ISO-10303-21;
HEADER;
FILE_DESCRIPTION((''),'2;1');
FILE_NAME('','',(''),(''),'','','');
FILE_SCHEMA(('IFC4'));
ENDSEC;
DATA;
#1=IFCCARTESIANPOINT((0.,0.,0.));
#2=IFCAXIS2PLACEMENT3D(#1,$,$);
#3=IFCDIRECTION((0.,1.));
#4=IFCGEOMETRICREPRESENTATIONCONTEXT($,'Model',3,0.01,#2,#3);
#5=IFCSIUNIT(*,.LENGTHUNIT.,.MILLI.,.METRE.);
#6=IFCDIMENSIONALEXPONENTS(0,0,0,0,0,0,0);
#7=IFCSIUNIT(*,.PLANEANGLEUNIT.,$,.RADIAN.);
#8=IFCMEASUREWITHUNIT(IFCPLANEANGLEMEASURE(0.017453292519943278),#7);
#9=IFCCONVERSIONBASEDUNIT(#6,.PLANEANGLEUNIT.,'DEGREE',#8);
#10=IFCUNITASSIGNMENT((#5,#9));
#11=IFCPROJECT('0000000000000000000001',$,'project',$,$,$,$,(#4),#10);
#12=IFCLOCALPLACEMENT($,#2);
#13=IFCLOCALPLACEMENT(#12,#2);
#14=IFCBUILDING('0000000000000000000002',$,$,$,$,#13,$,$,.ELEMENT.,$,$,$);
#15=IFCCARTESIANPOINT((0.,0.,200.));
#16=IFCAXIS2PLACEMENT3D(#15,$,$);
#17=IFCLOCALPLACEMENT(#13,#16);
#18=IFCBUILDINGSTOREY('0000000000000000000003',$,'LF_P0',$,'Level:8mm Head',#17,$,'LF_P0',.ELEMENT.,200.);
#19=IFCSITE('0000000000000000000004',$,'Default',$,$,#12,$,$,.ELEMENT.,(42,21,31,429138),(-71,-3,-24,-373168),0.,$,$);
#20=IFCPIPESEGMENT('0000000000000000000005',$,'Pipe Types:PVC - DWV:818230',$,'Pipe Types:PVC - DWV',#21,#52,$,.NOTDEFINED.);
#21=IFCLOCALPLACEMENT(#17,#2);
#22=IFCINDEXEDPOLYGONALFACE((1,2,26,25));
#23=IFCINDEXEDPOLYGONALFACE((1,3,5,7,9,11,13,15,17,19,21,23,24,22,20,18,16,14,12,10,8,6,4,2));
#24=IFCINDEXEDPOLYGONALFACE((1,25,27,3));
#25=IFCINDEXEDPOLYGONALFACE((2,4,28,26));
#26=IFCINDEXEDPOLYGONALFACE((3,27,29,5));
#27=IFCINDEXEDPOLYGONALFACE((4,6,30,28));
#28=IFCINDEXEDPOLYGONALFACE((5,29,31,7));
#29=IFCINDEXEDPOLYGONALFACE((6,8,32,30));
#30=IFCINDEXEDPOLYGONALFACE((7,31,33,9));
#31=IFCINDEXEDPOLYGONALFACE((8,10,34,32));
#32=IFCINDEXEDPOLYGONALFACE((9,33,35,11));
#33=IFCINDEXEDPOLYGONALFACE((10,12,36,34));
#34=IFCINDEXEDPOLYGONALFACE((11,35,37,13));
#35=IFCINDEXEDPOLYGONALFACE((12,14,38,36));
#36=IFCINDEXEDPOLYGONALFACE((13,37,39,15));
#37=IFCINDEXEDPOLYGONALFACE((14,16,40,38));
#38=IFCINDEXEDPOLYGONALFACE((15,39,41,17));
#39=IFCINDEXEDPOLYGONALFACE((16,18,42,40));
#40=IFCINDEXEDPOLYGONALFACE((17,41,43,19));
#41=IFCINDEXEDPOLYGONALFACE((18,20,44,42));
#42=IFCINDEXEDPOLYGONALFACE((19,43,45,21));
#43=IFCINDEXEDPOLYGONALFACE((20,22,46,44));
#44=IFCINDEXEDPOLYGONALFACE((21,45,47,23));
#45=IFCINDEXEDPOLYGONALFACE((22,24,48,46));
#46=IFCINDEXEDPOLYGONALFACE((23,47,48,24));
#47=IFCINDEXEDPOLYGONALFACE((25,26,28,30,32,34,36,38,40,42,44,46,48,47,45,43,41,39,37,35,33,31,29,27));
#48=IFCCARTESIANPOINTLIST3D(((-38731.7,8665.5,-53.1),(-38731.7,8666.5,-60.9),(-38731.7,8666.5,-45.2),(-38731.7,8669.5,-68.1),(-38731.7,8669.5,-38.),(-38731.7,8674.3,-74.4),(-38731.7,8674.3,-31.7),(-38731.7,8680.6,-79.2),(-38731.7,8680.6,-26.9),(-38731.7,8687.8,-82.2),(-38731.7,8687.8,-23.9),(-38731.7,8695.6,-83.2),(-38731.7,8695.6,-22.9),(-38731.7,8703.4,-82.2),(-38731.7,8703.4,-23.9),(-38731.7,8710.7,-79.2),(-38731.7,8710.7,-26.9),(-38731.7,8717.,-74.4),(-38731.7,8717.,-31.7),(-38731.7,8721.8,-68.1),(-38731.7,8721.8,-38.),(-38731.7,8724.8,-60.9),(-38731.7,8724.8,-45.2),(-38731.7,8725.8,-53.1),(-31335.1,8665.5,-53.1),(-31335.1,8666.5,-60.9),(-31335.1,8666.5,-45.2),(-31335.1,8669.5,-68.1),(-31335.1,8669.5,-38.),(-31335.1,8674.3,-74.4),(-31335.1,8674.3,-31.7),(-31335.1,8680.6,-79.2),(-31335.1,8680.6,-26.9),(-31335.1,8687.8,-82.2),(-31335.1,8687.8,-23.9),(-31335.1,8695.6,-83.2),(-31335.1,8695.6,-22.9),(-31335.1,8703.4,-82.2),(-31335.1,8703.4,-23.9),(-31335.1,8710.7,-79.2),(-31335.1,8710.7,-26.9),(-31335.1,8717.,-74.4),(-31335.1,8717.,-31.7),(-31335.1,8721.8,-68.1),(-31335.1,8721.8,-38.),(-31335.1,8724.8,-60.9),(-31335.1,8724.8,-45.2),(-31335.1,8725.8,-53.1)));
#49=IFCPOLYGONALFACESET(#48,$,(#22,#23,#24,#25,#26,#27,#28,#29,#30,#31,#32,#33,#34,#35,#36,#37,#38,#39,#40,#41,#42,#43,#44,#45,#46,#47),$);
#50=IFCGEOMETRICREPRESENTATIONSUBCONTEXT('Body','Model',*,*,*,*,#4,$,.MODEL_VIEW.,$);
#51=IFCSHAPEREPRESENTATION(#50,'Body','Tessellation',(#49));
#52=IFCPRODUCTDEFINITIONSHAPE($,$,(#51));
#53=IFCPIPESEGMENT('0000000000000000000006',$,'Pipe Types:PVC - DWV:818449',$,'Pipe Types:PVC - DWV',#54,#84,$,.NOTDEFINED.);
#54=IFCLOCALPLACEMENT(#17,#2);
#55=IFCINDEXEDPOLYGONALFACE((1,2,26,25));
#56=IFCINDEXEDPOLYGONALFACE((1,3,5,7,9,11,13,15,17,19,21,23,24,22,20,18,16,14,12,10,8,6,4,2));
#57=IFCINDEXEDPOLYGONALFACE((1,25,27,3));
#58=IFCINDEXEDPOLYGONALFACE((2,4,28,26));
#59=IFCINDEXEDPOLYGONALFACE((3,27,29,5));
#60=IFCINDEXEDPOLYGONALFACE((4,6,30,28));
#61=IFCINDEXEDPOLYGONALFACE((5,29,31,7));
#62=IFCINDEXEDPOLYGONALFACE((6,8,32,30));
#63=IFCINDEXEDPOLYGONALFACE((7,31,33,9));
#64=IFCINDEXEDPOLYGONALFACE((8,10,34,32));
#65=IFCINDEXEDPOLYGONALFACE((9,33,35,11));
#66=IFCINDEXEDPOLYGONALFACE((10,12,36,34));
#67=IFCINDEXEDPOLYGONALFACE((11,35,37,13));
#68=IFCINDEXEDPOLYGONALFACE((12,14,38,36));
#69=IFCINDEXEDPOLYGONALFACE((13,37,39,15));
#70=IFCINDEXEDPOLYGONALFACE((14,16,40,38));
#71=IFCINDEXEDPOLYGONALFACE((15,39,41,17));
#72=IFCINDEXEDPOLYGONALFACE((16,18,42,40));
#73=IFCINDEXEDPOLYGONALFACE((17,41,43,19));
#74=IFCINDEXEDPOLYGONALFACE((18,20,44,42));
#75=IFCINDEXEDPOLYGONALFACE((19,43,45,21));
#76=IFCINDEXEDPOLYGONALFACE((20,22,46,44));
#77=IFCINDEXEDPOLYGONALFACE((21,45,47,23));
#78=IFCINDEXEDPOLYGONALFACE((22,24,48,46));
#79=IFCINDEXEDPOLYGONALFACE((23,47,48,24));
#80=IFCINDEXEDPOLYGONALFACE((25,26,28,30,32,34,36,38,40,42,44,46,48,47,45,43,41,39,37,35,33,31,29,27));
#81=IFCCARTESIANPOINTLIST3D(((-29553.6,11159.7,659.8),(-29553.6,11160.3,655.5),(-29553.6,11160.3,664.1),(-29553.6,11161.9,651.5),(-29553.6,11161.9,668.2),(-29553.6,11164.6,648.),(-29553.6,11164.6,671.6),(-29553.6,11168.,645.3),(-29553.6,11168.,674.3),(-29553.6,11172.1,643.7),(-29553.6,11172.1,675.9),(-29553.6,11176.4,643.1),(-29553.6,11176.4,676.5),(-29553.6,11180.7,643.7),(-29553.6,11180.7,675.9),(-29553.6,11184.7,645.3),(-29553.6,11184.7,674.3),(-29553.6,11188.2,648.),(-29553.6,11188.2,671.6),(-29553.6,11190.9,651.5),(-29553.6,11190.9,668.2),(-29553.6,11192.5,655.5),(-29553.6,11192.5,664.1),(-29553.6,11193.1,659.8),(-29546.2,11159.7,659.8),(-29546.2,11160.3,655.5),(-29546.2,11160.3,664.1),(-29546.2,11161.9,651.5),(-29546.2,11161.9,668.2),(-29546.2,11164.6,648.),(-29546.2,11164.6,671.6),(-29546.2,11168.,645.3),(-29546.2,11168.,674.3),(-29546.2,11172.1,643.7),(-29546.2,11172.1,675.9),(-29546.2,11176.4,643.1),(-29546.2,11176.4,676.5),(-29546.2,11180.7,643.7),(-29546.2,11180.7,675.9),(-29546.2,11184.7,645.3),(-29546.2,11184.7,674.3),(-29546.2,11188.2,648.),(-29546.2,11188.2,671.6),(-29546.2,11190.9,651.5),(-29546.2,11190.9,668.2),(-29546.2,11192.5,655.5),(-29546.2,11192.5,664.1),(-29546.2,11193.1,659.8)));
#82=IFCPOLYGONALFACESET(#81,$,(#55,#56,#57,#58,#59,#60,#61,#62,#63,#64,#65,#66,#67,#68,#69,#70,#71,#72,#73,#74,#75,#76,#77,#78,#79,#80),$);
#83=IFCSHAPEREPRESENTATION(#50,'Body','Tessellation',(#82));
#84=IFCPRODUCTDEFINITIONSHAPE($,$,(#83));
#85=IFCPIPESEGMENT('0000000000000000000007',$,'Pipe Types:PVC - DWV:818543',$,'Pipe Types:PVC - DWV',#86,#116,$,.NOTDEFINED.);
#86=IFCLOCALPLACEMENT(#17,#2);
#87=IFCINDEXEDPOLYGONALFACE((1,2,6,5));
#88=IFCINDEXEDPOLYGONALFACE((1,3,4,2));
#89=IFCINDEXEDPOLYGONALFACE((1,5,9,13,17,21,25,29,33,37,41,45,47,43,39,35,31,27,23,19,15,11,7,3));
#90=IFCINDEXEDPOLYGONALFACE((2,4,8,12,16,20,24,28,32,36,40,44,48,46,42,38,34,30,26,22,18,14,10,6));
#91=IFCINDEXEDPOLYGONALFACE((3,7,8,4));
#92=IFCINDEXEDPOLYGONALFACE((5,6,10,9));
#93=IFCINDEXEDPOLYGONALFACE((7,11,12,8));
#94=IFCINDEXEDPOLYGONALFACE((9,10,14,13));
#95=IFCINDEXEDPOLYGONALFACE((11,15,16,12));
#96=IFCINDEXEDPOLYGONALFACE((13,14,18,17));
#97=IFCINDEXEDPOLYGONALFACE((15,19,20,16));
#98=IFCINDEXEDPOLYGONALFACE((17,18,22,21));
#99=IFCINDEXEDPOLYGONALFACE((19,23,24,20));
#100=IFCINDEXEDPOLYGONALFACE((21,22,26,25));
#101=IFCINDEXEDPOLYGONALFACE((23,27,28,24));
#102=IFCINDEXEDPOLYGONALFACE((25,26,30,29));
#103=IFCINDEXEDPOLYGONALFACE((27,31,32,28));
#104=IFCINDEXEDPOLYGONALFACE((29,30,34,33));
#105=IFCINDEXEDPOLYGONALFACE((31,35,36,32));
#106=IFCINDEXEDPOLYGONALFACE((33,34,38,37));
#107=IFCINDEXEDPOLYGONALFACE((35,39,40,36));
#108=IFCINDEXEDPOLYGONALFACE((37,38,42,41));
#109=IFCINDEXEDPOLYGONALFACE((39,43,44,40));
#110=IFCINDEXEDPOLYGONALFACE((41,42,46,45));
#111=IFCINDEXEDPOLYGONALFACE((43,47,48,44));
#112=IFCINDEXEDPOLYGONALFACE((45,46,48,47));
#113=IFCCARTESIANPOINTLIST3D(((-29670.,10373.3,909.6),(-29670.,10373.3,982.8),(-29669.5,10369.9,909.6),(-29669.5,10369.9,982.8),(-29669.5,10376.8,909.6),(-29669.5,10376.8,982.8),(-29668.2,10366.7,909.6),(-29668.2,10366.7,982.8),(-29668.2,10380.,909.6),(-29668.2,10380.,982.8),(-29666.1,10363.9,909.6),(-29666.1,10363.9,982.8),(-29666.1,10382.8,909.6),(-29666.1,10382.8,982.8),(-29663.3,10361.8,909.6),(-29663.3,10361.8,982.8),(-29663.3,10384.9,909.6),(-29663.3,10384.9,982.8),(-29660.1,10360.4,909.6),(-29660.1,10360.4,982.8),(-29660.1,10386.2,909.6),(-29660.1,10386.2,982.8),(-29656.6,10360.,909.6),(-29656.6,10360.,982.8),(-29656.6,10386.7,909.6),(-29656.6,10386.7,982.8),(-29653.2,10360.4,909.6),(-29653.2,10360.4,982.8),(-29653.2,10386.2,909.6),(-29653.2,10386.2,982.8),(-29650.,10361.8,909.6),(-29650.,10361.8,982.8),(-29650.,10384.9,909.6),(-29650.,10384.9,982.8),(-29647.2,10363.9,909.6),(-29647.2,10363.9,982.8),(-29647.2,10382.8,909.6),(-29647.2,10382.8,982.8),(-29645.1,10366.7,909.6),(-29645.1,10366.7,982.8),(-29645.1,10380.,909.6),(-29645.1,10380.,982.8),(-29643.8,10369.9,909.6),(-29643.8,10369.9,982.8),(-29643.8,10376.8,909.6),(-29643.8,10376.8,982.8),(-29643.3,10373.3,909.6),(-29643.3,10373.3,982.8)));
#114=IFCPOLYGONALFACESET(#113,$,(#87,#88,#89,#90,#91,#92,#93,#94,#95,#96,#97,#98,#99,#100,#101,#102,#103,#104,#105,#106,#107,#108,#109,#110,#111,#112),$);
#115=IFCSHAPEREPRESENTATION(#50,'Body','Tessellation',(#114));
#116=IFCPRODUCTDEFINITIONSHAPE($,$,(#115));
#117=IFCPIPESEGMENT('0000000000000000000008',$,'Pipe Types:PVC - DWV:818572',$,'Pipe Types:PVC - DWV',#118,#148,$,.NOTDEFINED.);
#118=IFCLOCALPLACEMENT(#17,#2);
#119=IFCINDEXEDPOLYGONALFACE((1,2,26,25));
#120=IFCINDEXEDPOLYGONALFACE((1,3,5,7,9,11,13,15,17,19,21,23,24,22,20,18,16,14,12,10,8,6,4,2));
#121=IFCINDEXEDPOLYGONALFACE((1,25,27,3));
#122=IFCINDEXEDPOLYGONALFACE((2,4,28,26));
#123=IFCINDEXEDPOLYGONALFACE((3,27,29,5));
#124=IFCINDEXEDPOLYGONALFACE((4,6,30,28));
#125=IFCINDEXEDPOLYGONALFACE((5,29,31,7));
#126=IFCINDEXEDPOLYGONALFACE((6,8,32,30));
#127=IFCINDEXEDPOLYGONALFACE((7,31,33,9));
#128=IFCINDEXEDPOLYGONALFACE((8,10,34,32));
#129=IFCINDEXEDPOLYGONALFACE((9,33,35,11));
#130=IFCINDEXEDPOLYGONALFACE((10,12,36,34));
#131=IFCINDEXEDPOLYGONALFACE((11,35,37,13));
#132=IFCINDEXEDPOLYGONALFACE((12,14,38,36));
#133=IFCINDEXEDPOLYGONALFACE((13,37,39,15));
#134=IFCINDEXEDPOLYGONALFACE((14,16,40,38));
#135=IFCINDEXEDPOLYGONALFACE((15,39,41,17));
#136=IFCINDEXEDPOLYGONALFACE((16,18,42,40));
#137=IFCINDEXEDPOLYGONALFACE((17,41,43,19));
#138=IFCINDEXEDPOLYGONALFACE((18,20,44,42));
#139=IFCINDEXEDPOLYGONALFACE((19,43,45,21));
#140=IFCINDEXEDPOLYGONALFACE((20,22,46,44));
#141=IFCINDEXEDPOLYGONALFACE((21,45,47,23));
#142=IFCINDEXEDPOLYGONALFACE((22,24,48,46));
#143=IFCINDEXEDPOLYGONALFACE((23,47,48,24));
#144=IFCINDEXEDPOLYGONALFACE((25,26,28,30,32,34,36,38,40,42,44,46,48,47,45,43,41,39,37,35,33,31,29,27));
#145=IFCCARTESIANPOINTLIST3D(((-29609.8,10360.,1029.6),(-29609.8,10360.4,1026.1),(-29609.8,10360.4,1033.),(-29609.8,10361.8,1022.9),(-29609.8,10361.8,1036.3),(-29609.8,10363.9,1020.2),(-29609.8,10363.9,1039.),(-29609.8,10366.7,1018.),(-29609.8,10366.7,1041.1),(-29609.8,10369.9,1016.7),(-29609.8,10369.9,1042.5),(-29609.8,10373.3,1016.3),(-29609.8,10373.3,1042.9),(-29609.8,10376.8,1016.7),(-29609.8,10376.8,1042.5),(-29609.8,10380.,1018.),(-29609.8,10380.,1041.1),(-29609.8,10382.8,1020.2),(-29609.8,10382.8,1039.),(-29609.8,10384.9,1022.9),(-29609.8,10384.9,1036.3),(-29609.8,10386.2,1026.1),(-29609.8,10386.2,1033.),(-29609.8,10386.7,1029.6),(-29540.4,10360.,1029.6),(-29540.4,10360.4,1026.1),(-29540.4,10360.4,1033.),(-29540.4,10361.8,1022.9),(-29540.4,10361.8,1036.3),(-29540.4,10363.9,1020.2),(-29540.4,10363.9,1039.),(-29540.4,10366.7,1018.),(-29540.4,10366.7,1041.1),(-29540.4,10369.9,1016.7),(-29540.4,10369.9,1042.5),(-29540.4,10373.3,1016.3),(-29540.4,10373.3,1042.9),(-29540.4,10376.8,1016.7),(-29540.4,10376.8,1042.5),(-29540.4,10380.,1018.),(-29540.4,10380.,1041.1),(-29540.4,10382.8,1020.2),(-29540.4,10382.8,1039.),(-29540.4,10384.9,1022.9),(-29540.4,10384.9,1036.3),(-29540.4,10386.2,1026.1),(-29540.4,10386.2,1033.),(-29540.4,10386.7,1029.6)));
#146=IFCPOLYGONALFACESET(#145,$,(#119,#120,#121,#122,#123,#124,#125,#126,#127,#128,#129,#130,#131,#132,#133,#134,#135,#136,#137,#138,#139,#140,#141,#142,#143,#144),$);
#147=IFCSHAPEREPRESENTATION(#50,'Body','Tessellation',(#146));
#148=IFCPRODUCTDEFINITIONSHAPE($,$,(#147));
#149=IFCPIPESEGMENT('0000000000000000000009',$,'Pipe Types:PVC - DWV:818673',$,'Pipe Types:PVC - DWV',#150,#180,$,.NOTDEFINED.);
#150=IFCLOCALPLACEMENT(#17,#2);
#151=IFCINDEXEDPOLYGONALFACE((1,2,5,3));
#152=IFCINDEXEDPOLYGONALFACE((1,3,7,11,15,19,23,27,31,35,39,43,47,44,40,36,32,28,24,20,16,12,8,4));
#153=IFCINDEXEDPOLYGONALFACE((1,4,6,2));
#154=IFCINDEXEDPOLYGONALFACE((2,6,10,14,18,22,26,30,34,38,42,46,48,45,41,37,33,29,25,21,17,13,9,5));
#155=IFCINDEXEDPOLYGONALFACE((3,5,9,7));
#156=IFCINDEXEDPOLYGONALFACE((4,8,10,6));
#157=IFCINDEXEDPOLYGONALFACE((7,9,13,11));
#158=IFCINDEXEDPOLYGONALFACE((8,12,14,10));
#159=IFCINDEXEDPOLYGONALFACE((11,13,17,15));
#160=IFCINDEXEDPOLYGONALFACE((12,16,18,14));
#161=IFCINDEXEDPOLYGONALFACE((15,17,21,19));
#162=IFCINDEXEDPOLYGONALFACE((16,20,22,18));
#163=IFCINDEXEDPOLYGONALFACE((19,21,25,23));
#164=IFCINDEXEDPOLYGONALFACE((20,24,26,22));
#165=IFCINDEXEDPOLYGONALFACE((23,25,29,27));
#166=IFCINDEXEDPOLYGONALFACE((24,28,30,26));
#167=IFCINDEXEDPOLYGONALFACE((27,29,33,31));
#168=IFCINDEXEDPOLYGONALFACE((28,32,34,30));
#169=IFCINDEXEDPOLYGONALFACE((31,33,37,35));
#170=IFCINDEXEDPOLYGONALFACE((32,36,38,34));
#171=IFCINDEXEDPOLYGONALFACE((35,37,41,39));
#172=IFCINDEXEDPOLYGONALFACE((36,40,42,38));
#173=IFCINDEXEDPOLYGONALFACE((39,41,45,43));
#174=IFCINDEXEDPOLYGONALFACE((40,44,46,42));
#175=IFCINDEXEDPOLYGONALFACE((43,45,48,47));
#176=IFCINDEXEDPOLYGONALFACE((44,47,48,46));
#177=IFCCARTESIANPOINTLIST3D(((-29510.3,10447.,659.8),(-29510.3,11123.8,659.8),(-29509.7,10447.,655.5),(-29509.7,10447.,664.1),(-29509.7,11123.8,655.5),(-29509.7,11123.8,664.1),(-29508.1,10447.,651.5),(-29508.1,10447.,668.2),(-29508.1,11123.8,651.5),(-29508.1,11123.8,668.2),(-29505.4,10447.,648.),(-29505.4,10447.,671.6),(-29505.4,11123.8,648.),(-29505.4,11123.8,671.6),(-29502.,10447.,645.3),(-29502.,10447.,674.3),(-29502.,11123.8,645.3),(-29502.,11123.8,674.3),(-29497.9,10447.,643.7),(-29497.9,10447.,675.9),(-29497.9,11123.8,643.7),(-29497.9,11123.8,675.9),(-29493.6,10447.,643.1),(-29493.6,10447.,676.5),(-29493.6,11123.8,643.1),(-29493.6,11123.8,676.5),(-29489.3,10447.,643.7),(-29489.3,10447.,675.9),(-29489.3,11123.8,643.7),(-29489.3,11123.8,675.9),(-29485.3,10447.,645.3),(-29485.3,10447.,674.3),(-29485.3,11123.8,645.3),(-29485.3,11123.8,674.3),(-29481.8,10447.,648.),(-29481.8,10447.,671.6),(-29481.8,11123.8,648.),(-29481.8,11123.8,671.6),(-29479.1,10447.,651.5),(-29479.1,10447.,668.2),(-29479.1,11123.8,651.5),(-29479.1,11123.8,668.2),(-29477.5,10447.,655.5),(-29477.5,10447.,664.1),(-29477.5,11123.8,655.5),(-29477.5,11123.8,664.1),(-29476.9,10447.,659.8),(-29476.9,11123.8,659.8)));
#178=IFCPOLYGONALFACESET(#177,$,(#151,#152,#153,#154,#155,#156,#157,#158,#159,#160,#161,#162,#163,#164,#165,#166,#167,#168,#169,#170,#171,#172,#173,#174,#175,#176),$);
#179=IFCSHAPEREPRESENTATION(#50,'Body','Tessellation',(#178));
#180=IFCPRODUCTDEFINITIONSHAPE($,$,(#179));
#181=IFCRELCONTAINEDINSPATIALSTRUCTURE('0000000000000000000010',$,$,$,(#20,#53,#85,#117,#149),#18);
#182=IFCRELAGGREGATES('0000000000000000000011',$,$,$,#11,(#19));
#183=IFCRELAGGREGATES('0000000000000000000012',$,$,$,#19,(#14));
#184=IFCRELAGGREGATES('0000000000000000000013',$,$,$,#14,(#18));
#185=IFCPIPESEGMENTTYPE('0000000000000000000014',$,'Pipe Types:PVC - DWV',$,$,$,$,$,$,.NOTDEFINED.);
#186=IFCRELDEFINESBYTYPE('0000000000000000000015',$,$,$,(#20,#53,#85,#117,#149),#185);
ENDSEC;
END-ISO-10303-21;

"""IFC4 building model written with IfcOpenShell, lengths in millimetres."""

from ifc_helpers import new_model, entity, si_unit, converted_unit, direction, frame, origin, place, context, subcontext, project, spatial, arc, indexed_curve, outline, extrude, type_object, element, save


model = new_model("IFC4")

# Units and contexts
model_context = context("Model", 3, precision=0.01, world=origin(), true_north=direction((0.0, 1.0)))
body_context = subcontext(model_context, "Body", "Model", "MODEL_VIEW")
ifc_project = project(units=[si_unit("LENGTHUNIT", "METRE", prefix="MILLI"), converted_unit("PLANEANGLEUNIT", "DEGREE", entity("IfcPlaneAngleMeasure", 0.017453292519943278), si_unit("PLANEANGLEUNIT", "RADIAN"), dimensions=[0, 0, 0, 0, 0, 0, 0])], contexts=[model_context])

# Site, building, storey
site_placement = place(None, origin())
site = spatial("IfcSite", under=ifc_project, at=site_placement, Name="Default", CompositionType="ELEMENT", RefLatitude=(42, 21, 31, 429138), RefLongitude=(-71, -3, -24, -373168), RefElevation=0.0)
building_placement = place(site_placement, origin())
building = spatial("IfcBuilding", under=site, at=building_placement, CompositionType="ELEMENT")
storey_placement = place(building_placement, frame((0.0, 0.0, 200.0)))
storey = spatial("IfcBuildingStorey", under=building, at=storey_placement, Name="LF_P0", ObjectType="Level:8mm Head", LongName="LF_P0", CompositionType="ELEMENT", Elevation=200.0)

# Pipe segments
pipe_segment_type_1 = type_object("IfcPipeSegmentType", Name="Pipe Types:PVC - DWV", PredefinedType="NOTDEFINED")
pipe_segment_1_placement = place(storey_placement, origin())
element("IfcPipeSegment", 1, at=pipe_segment_1_placement, inside=storey, type_object=pipe_segment_type_1, Name="Pipe Types:PVC - DWV:818230", ObjectType="Pipe Types:PVC - DWV", PredefinedType="NOTDEFINED", context=body_context, shape_type="SweptSolid", body=[
    extrude(outline(indexed_curve([(30.2, 0.0), (21.3, 21.3), (0.0, 30.2), (-21.3, 21.3), (-30.2, 0.0), (-21.3, -21.3), (0.0, -30.2), (21.3, -21.3)], segments=[arc(1, 2, 3), arc(3, 4, 5), arc(5, 6, 7), arc(7, 8, 1)], self_intersect=False)), frame((-38731.7, 8695.6, -53.1), z_axis=(1.0, 0.0, 0.0), x_axis=(0.0, -1.0, 0.0)), (0.0, 0.0, 1.0), 7396.6),
])
pipe_segment_2_placement = place(storey_placement, origin())
element("IfcPipeSegment", 2, at=pipe_segment_2_placement, inside=storey, type_object=pipe_segment_type_1, Name="Pipe Types:PVC - DWV:818449", ObjectType="Pipe Types:PVC - DWV", PredefinedType="NOTDEFINED", context=body_context, shape_type="SweptSolid", body=[
    extrude(outline(indexed_curve([(16.7, 0.0), (11.8, 11.8), (0.0, 16.7), (-11.8, 11.8), (-16.7, 0.0), (-11.8, -11.8), (0.0, -16.7), (11.8, -11.8)], segments=[arc(1, 2, 3), arc(3, 4, 5), arc(5, 6, 7), arc(7, 8, 1)], self_intersect=False)), frame((-29553.6, 11176.4, 659.8), z_axis=(1.0, 0.0, 0.0), x_axis=(0.0, -1.0, 0.0)), (0.0, 0.0, 1.0), 7.4),
])
pipe_segment_3_placement = place(storey_placement, origin())
element("IfcPipeSegment", 3, at=pipe_segment_3_placement, inside=storey, type_object=pipe_segment_type_1, Name="Pipe Types:PVC - DWV:818543", ObjectType="Pipe Types:PVC - DWV", PredefinedType="NOTDEFINED", context=body_context, shape_type="SweptSolid", body=[
    extrude(outline(indexed_curve([(13.3, 0.0), (9.4, 9.4), (0.0, 13.3), (-9.4, 9.4), (-13.3, 0.0), (-9.4, -9.4), (0.0, -13.3), (9.4, -9.4)], segments=[arc(1, 2, 3), arc(3, 4, 5), arc(5, 6, 7), arc(7, 8, 1)], self_intersect=False)), frame((-29656.6, 10373.3, 909.6), z_axis=(0.0, 0.0, 1.0), x_axis=(-1.0, 0.0, 0.0)), (0.0, 0.0, 1.0), 73.2),
])
pipe_segment_4_placement = place(storey_placement, origin())
element("IfcPipeSegment", 4, at=pipe_segment_4_placement, inside=storey, type_object=pipe_segment_type_1, Name="Pipe Types:PVC - DWV:818572", ObjectType="Pipe Types:PVC - DWV", PredefinedType="NOTDEFINED", context=body_context, shape_type="SweptSolid", body=[
    extrude(outline(indexed_curve([(13.3, 0.0), (9.4, 9.4), (0.0, 13.3), (-9.4, 9.4), (-13.3, 0.0), (-9.4, -9.4), (0.0, -13.3), (9.4, -9.4)], segments=[arc(1, 2, 3), arc(3, 4, 5), arc(5, 6, 7), arc(7, 8, 1)], self_intersect=False)), frame((-29609.8, 10373.3, 1029.6), z_axis=(1.0, 0.0, 0.0), x_axis=(0.0, -1.0, 0.0)), (0.0, 0.0, 1.0), 69.4),
])
pipe_segment_5_placement = place(storey_placement, origin())
element("IfcPipeSegment", 5, at=pipe_segment_5_placement, inside=storey, type_object=pipe_segment_type_1, Name="Pipe Types:PVC - DWV:818673", ObjectType="Pipe Types:PVC - DWV", PredefinedType="NOTDEFINED", context=body_context, shape_type="SweptSolid", body=[
    extrude(outline(indexed_curve([(16.7, 0.0), (11.8, 11.8), (0.0, 16.7), (-11.8, 11.8), (-16.7, 0.0), (-11.8, -11.8), (0.0, -16.7), (11.8, -11.8)], segments=[arc(1, 2, 3), arc(3, 4, 5), arc(5, 6, 7), arc(7, 8, 1)], self_intersect=False)), frame((-29493.6, 10447.0, 659.8), z_axis=(0.0, 1.0, 0.0), x_axis=(-1.0, 0.0, 0.0)), (0.0, 0.0, 1.0), 676.8),
])

save(model, "model.ifc")
